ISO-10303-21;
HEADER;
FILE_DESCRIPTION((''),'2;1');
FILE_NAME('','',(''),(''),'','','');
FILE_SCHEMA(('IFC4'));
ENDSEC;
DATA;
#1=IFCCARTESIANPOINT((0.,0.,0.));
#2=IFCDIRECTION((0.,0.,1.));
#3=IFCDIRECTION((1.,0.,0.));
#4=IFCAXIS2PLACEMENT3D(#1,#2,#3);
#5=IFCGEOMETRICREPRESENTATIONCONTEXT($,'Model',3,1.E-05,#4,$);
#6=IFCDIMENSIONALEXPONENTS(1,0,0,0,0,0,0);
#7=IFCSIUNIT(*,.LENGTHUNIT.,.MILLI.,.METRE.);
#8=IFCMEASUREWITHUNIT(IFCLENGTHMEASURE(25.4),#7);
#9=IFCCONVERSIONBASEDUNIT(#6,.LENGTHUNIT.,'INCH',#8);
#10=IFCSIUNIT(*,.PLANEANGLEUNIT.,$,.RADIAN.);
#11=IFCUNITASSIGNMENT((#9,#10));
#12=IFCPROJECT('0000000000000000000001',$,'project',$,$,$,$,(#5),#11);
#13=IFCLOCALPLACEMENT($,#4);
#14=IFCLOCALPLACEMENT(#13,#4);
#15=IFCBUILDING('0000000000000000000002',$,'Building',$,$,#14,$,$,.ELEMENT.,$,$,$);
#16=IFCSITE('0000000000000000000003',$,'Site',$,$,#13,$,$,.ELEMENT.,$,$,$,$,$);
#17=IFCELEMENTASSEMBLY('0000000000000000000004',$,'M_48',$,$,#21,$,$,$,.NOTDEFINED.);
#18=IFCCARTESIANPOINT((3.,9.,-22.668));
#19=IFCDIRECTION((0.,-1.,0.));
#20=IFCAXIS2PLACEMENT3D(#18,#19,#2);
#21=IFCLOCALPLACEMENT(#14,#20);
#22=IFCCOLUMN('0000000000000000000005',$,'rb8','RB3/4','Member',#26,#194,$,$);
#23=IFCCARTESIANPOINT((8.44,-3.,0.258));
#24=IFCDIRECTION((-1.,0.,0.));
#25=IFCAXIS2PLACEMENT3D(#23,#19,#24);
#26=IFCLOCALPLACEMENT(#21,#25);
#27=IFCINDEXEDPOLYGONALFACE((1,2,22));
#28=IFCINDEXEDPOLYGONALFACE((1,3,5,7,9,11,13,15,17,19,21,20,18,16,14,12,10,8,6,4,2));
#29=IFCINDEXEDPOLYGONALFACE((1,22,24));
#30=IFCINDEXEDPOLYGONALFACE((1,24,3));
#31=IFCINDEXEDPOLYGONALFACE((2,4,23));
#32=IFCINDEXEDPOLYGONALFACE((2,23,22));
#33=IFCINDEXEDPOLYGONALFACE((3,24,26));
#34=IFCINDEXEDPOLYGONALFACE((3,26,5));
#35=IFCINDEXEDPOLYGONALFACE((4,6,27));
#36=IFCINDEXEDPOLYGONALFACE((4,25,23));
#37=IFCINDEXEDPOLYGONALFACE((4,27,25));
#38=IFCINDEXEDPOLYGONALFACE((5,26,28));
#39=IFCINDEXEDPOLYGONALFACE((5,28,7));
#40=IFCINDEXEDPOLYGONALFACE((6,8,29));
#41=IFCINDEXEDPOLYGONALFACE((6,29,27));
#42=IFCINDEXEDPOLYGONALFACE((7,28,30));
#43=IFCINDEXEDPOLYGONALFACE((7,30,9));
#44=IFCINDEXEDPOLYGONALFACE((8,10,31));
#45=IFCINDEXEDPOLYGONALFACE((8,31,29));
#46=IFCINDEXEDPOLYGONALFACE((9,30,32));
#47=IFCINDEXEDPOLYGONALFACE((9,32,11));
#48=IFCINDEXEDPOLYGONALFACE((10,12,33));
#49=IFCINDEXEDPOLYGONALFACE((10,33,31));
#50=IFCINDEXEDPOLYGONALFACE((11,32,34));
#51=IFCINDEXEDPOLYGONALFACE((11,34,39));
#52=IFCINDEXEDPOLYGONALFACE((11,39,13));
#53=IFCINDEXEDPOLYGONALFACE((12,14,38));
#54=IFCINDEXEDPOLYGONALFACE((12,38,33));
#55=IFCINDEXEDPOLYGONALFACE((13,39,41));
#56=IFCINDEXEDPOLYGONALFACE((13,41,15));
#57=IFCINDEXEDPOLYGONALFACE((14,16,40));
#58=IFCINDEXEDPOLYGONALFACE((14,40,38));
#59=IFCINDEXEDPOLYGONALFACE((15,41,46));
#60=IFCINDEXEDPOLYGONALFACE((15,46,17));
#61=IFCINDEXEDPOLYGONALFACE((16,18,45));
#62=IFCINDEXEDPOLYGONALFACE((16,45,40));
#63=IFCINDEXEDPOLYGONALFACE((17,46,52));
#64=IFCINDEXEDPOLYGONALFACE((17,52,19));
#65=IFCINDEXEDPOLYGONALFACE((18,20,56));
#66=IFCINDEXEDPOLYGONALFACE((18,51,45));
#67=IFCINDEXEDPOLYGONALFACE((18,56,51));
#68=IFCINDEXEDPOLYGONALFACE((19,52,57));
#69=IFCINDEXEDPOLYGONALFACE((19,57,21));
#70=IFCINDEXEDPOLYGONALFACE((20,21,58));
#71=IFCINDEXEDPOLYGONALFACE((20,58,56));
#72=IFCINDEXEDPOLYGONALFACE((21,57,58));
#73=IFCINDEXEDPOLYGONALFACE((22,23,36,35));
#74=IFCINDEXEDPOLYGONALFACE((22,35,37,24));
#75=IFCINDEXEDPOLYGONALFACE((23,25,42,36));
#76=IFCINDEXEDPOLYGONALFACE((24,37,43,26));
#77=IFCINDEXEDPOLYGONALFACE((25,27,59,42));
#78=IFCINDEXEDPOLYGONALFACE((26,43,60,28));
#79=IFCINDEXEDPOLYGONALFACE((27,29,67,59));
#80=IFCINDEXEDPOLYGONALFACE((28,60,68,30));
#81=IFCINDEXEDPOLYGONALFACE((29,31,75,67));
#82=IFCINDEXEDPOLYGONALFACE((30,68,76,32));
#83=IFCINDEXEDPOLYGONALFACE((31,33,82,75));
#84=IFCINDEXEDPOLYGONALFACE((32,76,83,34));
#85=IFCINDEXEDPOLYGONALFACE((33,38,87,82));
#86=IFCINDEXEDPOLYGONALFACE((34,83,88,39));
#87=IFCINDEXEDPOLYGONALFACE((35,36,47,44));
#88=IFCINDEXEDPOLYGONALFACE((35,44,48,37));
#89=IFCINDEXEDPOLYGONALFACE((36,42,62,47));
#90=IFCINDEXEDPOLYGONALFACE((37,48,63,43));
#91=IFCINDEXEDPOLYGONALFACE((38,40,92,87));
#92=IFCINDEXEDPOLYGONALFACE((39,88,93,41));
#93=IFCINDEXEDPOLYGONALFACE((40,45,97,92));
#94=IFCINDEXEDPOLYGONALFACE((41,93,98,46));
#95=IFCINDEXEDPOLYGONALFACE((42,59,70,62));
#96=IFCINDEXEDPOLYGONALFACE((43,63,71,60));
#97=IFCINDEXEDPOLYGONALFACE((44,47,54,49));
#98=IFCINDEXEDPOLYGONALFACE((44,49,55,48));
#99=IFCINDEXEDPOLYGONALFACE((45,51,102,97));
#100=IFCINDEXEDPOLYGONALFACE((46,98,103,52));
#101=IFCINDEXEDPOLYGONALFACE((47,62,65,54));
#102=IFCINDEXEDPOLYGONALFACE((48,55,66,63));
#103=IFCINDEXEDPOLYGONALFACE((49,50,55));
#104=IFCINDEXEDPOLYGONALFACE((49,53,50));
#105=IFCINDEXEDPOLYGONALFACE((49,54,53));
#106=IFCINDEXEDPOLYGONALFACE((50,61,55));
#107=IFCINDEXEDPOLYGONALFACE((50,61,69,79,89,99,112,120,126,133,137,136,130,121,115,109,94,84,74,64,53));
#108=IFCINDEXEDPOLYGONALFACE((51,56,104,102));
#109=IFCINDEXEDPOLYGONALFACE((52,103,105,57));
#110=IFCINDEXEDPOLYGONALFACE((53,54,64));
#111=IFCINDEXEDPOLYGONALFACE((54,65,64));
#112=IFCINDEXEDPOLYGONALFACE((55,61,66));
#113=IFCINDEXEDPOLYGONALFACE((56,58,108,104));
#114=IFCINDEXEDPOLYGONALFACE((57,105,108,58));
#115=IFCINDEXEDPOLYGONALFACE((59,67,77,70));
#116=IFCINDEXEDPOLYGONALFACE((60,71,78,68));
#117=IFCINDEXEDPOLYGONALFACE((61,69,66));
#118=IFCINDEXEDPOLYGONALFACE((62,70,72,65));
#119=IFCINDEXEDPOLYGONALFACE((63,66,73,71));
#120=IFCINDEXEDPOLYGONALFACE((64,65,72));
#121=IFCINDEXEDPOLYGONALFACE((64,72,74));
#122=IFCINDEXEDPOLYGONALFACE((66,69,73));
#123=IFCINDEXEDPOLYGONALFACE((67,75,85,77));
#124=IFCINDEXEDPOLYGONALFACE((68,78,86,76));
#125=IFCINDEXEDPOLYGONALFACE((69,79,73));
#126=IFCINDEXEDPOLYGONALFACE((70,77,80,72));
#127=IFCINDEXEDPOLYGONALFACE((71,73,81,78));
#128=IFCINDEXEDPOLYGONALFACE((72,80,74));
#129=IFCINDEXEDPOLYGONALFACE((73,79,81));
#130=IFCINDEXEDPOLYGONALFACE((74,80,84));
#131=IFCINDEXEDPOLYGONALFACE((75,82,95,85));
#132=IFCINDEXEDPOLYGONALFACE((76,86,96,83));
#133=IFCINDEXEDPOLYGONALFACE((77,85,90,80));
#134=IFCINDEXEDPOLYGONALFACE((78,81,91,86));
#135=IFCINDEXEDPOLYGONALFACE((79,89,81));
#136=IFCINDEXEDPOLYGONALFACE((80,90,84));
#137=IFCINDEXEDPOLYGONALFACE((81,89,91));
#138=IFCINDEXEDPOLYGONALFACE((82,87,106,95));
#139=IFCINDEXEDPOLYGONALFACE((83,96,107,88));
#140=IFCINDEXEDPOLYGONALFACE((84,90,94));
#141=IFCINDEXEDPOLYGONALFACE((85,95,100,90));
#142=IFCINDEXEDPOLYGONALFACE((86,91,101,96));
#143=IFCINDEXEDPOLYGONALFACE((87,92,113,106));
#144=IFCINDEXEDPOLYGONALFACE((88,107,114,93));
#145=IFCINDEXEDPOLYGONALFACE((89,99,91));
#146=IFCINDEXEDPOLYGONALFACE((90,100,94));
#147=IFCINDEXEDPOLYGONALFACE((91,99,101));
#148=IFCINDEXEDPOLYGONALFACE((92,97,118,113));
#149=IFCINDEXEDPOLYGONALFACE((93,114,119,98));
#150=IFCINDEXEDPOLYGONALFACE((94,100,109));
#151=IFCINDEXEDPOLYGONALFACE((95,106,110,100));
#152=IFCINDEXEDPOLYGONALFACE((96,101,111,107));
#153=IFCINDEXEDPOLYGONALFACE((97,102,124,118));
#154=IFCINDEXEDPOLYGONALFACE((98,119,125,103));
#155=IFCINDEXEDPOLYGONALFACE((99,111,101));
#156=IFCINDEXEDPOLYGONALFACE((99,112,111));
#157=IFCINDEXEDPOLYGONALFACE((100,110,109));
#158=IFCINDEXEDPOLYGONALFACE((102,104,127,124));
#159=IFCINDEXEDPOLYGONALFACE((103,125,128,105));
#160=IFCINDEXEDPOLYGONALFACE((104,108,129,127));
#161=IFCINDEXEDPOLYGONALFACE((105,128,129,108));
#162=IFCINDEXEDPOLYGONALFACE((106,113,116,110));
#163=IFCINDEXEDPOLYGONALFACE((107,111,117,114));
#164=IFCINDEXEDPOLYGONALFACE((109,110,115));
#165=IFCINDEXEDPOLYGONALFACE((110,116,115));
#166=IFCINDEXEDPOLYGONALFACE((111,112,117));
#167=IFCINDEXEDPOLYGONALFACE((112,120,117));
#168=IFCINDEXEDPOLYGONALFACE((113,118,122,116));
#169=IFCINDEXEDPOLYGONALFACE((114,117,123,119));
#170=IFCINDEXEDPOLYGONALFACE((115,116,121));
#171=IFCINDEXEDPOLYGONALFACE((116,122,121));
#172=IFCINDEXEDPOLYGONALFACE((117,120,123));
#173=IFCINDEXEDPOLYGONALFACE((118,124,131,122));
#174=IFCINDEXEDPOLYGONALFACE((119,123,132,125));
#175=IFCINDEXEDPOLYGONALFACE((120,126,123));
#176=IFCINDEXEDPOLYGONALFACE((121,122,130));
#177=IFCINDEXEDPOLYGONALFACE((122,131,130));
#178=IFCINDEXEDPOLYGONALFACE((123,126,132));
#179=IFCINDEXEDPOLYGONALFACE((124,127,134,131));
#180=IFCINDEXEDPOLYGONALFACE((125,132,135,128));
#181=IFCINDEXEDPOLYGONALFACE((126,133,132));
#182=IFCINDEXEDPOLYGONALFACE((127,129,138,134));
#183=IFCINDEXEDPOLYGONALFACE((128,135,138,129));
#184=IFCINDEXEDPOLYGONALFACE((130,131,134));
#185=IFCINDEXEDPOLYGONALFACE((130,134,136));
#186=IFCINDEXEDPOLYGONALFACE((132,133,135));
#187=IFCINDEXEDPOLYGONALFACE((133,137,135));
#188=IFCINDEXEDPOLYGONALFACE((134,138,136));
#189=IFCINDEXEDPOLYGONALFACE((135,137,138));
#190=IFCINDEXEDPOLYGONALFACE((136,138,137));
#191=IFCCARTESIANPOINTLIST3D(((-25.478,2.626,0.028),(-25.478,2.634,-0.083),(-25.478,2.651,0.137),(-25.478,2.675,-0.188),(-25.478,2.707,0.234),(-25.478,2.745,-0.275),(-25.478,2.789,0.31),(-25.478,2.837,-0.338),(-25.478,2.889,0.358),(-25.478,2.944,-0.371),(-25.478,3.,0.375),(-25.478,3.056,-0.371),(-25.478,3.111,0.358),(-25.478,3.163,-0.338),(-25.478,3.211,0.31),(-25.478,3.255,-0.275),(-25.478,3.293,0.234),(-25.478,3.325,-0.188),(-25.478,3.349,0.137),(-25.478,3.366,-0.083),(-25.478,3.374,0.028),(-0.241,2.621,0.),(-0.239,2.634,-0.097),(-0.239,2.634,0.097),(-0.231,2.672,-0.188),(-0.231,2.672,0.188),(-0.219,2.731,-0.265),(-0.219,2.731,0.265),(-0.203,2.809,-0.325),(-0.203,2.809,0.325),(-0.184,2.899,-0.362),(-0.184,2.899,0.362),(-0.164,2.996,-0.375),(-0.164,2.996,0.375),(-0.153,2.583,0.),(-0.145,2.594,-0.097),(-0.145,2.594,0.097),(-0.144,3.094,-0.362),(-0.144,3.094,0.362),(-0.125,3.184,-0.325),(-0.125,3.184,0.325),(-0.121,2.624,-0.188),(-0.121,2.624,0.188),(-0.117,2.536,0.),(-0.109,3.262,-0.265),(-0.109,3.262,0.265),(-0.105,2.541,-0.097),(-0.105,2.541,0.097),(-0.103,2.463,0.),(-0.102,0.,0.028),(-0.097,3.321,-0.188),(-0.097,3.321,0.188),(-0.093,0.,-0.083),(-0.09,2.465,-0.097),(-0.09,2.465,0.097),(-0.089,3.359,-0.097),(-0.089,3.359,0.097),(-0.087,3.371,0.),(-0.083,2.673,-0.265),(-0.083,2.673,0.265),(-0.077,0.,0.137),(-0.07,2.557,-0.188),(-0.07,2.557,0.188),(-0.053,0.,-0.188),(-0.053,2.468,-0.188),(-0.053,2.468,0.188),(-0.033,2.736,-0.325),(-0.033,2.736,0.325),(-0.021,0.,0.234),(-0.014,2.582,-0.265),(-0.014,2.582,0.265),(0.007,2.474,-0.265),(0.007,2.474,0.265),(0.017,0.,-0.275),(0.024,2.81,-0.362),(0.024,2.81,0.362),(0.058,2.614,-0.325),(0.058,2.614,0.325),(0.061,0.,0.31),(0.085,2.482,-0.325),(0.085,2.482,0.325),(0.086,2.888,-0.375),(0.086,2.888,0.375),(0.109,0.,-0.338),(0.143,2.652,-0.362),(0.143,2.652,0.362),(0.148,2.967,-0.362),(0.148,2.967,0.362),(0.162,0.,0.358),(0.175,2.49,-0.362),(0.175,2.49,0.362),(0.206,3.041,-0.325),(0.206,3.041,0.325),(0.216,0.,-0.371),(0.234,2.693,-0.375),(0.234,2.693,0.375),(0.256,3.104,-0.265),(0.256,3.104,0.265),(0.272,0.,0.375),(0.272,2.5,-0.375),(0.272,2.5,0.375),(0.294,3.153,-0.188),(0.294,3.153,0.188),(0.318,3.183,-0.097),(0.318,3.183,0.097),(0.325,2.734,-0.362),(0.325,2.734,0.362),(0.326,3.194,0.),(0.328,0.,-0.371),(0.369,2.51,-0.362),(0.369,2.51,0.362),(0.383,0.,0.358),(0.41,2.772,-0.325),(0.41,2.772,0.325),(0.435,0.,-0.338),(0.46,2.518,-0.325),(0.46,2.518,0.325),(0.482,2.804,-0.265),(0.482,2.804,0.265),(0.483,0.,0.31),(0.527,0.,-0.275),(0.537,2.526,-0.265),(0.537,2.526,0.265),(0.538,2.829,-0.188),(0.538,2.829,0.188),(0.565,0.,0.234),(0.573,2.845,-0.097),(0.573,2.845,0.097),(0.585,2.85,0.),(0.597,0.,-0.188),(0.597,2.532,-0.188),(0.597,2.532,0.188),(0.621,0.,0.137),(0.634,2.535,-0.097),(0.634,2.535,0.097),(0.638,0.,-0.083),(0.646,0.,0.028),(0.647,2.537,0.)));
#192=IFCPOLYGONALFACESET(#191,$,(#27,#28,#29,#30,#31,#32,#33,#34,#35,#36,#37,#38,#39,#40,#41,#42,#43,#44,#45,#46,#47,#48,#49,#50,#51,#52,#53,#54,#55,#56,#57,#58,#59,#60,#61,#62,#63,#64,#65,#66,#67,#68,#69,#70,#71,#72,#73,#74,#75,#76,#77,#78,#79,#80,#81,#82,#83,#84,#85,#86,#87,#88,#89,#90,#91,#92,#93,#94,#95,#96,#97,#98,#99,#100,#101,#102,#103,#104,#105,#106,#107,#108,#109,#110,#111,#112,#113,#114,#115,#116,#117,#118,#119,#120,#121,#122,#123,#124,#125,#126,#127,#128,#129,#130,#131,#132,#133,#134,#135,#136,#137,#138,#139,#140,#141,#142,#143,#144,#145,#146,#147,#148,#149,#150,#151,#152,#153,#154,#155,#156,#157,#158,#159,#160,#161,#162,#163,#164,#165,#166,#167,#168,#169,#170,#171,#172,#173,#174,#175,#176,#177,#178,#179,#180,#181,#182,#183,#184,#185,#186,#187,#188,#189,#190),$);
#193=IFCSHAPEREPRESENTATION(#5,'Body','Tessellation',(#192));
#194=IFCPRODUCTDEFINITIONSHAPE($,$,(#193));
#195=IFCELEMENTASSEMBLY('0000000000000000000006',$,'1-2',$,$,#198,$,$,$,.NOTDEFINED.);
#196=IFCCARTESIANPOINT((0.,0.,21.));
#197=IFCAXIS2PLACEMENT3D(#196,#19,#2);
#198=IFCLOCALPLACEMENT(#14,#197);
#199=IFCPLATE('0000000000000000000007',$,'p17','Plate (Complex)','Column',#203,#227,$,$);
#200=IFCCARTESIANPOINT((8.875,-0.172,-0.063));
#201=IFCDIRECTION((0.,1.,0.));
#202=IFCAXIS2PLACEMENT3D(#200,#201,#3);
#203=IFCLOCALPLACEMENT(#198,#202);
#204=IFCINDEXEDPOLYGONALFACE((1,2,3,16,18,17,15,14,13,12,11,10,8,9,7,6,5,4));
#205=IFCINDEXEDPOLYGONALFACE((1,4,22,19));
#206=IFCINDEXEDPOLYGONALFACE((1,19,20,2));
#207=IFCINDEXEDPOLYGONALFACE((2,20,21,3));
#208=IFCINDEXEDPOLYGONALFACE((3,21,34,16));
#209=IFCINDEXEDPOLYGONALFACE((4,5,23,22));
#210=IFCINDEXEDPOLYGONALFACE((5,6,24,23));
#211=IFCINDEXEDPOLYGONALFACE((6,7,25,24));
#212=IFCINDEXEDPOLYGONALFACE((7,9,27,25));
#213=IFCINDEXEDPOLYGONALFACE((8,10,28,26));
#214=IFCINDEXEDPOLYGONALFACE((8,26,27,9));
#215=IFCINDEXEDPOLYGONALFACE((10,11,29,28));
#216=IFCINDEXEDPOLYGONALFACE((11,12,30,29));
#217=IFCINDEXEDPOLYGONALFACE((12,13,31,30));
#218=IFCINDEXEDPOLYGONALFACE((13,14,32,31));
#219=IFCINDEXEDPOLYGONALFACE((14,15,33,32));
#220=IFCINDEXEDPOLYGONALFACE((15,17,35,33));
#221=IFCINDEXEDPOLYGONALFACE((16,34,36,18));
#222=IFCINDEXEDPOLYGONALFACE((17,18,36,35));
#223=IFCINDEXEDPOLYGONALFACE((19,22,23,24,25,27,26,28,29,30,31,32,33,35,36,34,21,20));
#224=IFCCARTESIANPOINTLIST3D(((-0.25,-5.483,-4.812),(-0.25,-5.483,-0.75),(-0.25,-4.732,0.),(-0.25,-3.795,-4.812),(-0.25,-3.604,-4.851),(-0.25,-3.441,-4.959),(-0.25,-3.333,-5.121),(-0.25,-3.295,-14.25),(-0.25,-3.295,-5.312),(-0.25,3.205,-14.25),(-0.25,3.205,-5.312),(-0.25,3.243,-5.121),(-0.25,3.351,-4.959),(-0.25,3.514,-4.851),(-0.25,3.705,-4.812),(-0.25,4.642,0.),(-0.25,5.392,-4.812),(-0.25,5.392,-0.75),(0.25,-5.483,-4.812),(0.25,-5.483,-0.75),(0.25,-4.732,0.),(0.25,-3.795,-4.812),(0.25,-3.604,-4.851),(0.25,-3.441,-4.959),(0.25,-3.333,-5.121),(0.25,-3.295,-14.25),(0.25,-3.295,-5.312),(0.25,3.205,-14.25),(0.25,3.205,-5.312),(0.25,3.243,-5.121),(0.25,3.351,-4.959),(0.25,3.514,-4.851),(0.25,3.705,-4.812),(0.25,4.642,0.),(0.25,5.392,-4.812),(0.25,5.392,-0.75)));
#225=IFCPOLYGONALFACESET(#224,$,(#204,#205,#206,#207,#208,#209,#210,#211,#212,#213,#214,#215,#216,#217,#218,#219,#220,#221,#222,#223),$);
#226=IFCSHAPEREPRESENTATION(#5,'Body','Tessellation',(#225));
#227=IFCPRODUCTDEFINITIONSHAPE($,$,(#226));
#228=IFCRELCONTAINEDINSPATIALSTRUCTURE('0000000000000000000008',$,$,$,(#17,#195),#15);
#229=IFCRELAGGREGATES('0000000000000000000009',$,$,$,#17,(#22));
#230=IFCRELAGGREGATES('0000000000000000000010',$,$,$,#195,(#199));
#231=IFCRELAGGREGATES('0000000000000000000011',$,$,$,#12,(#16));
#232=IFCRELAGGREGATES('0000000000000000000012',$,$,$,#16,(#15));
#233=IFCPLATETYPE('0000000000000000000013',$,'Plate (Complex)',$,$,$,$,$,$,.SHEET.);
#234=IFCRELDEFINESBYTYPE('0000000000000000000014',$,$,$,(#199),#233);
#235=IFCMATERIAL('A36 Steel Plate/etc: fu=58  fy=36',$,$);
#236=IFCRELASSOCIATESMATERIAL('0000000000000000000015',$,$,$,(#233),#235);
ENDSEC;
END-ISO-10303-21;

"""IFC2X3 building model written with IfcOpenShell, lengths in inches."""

from ifc_helpers import new_model, entity, si_unit, converted_unit, frame, origin_with_axes, place, context, project, spatial, polyline, outline, extrude, source, transform, mapped, material, type_object, type_shapes, element, aggregate, save


model = new_model("IFC2X3")

# Units and contexts
model_context = context("Model", 3, precision=1e-05, world=origin_with_axes())
ifc_project = project(units=[converted_unit("LENGTHUNIT", "INCH", entity("IfcLengthMeasure", 25.4), si_unit("LENGTHUNIT", "METRE", prefix="MILLI"), dimensions=[1, 0, 0, 0, 0, 0, 0]), si_unit("PLANEANGLEUNIT", "RADIAN")], contexts=[model_context])

# Site, building
site_placement = place(None, origin_with_axes())
site = spatial("IfcSite", under=ifc_project, at=site_placement, Name="Site", CompositionType="ELEMENT")
building_placement = place(site_placement, origin_with_axes())
building = spatial("IfcBuilding", under=site, at=building_placement, Name="Building", CompositionType="ELEMENT")

# Element assembly, column
assembly_1_placement = place(building_placement, frame((3.0, 9.0, -22.668), z_axis=(0.0, -1.0, 0.0), x_axis=(0.0, 0.0, 1.0)))
assembly_1 = element("IfcElementAssembly", 1, at=assembly_1_placement, inside=building, Name="M_48", PredefinedType="NOTDEFINED")
column_1_placement = place(assembly_1_placement, frame((8.44, -3.0, 0.258), z_axis=(0.0, -1.0, 0.0), x_axis=(-1.0, 0.0, 0.0)))
cartesian_point_1 = entity("IfcCartesianPoint", [0.0, 0.0, 0.0])
ifc_direction_1 = entity("IfcDirection", [0.0, 0.0, 1.0])
ifc_direction_2 = entity("IfcDirection", [1.0, 0.0, 0.0])
column_1 = element("IfcColumn", 2, at=column_1_placement, Name="rb8", Description="RB3/4", ObjectType="Member", context=model_context, shape_type="SweptSolid", body=[
    entity("IfcSurfaceCurveSweptAreaSolid", entity("IfcCircleProfileDef", "AREA", None, entity("IfcAxis2Placement2D", entity("IfcCartesianPoint", [0.0, 0.0]), entity("IfcDirection", [1.0, 0.0])), 0.375), entity("IfcAxis2Placement3D", cartesian_point_1, ifc_direction_1, ifc_direction_2), entity("IfcPolyline", [entity("IfcCartesianPoint", [0.272, 0.0]), entity("IfcCartesianPoint", [0.272, 2.5]), entity("IfcCartesianPoint", [0.234, 2.693]), entity("IfcCartesianPoint", [0.086, 2.888]), entity("IfcCartesianPoint", [-0.164, 2.996]), entity("IfcCartesianPoint", [-25.478, 3.0])]), 0.0, 1.0, entity("IfcPlane", entity("IfcAxis2Placement3D", cartesian_point_1, ifc_direction_1, ifc_direction_2))),
])

# Shared definitions
ifc_material = material(Name="A36 Steel Plate/etc: fu=58  fy=36")

aggregate(assembly_1, [column_1])

# Element assembly, plate
assembly_2_placement = place(building_placement, frame((0.0, 0.0, 21.0), z_axis=(0.0, -1.0, 0.0), x_axis=(0.0, 0.0, 1.0)))
assembly_2 = element("IfcElementAssembly", 3, at=assembly_2_placement, inside=building, Name="1-2", PredefinedType="NOTDEFINED")
plate_type_1 = type_object("IfcPlateType", Name="Plate (Complex)", PredefinedType="SHEET", material=ifc_material)
shared_shape_1 = source(origin_with_axes(), model_context, "Body", "SweptSolid", [
    extrude(outline(polyline([(5.393, -4.812), (3.705, -4.812), (3.514, -4.851), (3.351, -4.959), (3.243, -5.121), (3.205, -5.312), (3.205, -14.25), (-3.295, -14.25), (-3.295, -5.312), (-3.333, -5.121), (-3.441, -4.959), (-3.604, -4.851), (-3.795, -4.812), (-5.482, -4.812), (-5.482, -0.75), (-4.732, 0.0), (4.643, 0.0), (5.393, -0.75), (5.393, -4.812)])), frame((-0.25, 0.0, 0.0), z_axis=(1.0, 0.0, 0.0), x_axis=(0.0, 1.0, 0.0)), (0.0, 0.0, 1.0), 0.5),
])
type_shapes(plate_type_1, [shared_shape_1])
plate_1_placement = place(assembly_2_placement, frame((8.875, -0.172, -0.063), z_axis=(0.0, 1.0, 0.0), x_axis=(1.0, 0.0, 0.0)))
plate_1 = element("IfcPlate", 4, at=plate_1_placement, type_object=plate_type_1, Name="p17", Description="Plate (Complex)", ObjectType="Column", context=model_context, shape_type="MappedRepresentation", body=[
    mapped(shared_shape_1, transform((0.0, 0.0, 0.0), scale=1.0)),
])
aggregate(assembly_2, [plate_1])

save(model, "model.ifc")
